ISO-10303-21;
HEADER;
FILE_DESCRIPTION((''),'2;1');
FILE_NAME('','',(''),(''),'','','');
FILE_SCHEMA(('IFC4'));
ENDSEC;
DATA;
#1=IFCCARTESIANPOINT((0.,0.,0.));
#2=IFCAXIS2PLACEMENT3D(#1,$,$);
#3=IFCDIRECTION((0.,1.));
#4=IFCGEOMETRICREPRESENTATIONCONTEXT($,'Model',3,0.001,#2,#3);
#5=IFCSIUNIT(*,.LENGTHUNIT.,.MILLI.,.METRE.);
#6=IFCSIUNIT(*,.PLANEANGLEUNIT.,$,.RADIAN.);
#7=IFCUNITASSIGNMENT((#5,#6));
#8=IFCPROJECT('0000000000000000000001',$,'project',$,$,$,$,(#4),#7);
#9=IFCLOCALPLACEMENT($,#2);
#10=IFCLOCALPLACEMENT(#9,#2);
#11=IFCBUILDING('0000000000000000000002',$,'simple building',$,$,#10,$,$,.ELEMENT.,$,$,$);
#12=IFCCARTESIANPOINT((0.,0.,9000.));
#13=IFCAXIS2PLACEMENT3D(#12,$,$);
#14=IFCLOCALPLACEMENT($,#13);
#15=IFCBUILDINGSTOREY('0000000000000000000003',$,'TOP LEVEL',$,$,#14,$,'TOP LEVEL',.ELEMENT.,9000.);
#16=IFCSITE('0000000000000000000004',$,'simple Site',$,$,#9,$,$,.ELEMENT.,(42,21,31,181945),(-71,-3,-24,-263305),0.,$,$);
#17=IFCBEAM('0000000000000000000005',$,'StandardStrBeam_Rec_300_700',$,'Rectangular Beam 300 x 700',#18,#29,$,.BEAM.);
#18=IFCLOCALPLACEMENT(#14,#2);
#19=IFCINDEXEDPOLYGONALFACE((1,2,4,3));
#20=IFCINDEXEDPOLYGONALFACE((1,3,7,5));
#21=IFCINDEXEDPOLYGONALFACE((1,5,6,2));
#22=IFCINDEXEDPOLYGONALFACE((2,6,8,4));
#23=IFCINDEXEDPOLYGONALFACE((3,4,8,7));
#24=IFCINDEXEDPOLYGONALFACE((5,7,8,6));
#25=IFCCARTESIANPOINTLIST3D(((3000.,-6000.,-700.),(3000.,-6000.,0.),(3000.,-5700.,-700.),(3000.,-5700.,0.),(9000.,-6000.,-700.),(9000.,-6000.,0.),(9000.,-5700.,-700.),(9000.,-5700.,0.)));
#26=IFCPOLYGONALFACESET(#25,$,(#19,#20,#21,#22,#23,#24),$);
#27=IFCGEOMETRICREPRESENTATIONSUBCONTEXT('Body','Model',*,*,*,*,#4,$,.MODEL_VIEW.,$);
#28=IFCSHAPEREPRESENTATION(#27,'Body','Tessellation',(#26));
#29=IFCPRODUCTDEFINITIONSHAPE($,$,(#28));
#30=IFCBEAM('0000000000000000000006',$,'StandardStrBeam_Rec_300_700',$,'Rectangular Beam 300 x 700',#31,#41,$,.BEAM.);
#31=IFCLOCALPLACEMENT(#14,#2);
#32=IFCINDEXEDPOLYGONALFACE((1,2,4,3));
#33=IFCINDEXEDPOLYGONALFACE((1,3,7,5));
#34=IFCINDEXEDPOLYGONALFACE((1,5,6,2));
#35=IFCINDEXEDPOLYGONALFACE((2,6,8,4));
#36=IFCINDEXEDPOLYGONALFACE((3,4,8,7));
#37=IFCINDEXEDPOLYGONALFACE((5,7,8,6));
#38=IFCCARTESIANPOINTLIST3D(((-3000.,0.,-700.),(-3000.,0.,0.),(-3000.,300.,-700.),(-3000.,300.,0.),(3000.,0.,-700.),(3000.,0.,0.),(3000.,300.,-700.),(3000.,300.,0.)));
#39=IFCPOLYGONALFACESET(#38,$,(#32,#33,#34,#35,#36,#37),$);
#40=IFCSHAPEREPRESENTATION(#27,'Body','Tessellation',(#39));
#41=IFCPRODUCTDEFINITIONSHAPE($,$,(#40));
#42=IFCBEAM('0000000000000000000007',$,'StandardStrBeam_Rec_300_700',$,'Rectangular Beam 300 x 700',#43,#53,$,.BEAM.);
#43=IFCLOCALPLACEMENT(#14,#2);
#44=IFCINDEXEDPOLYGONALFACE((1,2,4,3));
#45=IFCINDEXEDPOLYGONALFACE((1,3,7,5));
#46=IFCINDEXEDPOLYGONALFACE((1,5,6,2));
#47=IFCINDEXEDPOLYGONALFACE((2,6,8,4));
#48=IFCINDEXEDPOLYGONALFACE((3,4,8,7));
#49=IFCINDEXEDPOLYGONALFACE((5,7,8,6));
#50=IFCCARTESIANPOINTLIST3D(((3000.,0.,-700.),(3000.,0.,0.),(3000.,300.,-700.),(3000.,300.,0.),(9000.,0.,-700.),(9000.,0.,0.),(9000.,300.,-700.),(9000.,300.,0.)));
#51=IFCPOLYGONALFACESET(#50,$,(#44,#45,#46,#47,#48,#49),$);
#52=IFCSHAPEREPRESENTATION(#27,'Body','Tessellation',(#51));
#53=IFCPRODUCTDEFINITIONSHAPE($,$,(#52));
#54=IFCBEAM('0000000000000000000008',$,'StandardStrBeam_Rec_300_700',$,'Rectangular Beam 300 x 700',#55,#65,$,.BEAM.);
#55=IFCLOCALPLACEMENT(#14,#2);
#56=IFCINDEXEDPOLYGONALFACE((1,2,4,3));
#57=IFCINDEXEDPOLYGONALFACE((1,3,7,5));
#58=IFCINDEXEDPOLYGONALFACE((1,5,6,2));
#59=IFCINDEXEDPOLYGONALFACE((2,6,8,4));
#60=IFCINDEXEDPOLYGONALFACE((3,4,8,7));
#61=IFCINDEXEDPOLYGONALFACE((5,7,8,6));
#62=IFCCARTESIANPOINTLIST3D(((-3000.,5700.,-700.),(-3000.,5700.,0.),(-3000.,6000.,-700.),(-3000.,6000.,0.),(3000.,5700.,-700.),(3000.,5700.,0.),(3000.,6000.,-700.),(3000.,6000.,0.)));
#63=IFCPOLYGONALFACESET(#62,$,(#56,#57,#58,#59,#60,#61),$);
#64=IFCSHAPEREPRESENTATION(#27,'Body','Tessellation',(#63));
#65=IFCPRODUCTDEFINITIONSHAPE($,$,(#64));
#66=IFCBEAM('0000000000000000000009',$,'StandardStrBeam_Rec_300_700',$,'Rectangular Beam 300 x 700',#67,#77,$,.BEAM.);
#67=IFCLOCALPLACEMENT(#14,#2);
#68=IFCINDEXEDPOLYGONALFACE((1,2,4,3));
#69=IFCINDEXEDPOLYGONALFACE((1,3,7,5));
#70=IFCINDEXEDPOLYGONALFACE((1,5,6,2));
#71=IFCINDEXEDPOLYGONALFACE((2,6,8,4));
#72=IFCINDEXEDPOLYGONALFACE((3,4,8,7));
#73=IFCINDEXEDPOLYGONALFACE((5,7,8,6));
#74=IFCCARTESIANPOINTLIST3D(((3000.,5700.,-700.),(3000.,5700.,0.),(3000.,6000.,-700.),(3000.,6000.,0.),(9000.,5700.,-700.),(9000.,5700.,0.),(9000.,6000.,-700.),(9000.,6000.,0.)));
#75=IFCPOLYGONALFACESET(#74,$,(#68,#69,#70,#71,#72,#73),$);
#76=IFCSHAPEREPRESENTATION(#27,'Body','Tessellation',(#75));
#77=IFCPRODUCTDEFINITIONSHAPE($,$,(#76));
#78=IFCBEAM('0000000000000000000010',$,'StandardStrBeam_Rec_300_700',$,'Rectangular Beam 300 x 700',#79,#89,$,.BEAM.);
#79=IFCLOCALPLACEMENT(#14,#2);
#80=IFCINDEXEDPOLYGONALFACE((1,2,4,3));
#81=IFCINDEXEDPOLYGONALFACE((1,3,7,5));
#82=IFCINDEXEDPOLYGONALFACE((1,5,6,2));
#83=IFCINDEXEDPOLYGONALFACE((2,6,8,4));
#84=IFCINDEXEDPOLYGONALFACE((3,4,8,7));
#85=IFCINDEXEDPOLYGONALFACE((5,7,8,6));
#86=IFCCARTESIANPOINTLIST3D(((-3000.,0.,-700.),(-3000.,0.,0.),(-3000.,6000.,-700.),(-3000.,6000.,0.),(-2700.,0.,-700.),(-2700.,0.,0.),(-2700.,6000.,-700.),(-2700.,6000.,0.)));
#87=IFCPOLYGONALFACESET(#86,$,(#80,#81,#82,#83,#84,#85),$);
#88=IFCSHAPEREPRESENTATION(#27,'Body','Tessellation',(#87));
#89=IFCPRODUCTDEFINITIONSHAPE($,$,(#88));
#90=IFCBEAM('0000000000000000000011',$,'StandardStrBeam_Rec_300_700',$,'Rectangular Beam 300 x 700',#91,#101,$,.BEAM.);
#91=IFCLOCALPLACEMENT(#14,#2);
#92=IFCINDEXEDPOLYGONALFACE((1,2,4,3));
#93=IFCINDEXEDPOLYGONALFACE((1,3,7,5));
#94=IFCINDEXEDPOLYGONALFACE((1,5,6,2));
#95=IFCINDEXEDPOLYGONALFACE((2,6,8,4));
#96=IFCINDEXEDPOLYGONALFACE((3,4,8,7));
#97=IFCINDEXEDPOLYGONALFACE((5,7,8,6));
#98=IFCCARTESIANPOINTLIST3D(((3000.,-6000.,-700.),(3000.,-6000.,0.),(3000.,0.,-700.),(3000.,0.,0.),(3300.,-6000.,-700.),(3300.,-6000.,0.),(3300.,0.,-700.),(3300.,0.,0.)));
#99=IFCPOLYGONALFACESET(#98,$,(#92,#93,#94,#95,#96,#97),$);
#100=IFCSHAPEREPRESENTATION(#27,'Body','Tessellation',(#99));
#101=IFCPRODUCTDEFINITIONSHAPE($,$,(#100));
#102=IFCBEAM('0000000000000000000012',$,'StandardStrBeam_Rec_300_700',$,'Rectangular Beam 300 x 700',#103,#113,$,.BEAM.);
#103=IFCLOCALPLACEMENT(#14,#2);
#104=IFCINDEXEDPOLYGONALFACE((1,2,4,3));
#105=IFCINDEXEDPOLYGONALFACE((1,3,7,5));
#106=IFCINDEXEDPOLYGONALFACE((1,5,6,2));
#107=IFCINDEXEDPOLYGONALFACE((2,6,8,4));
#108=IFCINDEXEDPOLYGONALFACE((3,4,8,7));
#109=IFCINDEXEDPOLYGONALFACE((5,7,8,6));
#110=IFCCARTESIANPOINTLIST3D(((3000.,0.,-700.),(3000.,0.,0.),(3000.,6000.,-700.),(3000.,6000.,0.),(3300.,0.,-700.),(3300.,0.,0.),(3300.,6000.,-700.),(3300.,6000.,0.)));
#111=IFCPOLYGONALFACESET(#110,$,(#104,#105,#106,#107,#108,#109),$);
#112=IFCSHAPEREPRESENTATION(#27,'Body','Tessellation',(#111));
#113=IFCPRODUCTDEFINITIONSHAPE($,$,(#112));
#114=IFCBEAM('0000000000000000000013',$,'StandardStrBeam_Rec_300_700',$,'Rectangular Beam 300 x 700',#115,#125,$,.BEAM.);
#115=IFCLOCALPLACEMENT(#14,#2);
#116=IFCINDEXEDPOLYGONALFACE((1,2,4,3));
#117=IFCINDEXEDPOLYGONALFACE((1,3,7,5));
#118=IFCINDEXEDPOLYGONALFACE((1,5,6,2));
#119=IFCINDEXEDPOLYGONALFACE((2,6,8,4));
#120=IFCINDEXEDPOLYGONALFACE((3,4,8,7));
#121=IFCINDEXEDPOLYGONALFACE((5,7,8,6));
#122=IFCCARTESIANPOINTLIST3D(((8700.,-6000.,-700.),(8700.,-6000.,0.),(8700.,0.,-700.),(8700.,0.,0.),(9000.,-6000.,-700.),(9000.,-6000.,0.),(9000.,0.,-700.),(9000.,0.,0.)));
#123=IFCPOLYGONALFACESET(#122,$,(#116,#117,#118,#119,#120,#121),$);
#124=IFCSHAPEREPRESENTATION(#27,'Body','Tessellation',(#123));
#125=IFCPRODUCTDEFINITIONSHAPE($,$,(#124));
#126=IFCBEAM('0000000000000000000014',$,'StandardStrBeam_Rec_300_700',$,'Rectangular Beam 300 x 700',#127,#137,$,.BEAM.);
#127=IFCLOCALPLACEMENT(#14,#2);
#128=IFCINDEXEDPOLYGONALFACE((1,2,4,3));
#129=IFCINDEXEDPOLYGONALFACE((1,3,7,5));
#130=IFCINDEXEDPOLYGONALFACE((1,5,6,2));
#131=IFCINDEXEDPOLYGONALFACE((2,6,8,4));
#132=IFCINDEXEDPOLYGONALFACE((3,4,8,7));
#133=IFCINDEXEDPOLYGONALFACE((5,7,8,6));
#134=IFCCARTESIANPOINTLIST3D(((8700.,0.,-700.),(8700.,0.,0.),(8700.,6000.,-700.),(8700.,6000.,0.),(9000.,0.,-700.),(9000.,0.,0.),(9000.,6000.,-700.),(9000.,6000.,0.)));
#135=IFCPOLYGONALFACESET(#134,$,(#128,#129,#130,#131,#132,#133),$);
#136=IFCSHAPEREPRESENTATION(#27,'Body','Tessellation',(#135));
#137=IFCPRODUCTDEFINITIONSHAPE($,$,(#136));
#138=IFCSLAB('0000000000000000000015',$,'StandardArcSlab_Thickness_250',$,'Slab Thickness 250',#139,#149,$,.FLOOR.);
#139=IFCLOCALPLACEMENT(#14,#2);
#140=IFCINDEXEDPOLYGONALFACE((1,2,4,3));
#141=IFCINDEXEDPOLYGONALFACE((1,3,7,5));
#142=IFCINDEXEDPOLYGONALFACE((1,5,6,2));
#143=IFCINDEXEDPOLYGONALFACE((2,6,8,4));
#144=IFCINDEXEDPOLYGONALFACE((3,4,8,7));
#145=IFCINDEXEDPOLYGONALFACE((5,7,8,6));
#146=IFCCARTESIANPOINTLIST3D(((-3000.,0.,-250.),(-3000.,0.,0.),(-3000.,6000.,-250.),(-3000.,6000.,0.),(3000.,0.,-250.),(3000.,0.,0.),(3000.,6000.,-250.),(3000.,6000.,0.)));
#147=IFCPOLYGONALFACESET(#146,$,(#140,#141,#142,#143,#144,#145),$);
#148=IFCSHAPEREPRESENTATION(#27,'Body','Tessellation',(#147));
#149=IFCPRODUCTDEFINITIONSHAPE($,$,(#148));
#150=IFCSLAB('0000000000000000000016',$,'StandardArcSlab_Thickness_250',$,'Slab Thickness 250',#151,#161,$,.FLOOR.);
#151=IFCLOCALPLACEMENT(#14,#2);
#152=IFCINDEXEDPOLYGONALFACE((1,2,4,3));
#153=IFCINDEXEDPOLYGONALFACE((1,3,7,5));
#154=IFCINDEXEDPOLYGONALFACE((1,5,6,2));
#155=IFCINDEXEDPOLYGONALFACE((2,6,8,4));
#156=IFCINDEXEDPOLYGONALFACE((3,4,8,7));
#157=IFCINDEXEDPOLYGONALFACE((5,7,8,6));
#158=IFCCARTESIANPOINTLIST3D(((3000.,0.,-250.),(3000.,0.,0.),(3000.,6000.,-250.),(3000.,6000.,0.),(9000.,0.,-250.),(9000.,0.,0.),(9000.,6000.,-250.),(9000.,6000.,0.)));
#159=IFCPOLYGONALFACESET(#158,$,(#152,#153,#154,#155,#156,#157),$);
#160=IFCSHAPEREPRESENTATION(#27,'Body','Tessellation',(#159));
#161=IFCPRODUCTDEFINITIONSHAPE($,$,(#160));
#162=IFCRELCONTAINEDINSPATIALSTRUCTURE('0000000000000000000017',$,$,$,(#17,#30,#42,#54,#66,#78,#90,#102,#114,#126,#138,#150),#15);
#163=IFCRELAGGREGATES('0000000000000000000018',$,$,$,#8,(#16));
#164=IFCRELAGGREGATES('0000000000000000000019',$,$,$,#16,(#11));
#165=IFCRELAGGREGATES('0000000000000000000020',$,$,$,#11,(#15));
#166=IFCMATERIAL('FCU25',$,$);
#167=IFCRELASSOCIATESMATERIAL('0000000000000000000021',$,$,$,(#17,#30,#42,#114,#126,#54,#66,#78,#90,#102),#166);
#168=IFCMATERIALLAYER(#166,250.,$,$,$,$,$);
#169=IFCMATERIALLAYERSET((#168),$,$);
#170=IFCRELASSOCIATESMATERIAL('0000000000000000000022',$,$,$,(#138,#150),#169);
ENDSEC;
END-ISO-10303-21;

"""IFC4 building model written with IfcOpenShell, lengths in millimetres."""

from ifc_helpers import new_model, si_unit, direction, frame, origin, origin_with_axes, origin_2d_with_axis, place, context, subcontext, project, spatial, polyline, rectangle, outline, extrude, material, layer, layer_set, layer_usage, material_profile, profile_set, profile_usage, element, save


model = new_model("IFC4")

# Units and contexts
model_context = context("Model", 3, precision=0.001, world=origin(), true_north=direction((0.0, 1.0)))
body_context = subcontext(model_context, "Body", "Model", "MODEL_VIEW")
ifc_project = project(units=[si_unit("LENGTHUNIT", "METRE", prefix="MILLI"), si_unit("PLANEANGLEUNIT", "RADIAN")], contexts=[model_context])

# Site, building, storey
site_placement = place(None, origin())
site = spatial("IfcSite", under=ifc_project, at=site_placement, Name="simple Site", CompositionType="ELEMENT", RefLatitude=(42, 21, 31, 181945), RefLongitude=(-71, -3, -24, -263305), RefElevation=0.0)
building_placement = place(site_placement, origin())
building = spatial("IfcBuilding", under=site, at=building_placement, Name="simple building", CompositionType="ELEMENT")
storey_placement = place(None, frame((0.0, 0.0, 9000.0)))
storey = spatial("IfcBuildingStorey", under=building, at=storey_placement, Name="TOP LEVEL", LongName="TOP LEVEL", CompositionType="ELEMENT", Elevation=9000.0)

# Beams
ifc_material = material(Name="FCU25")
ifc_material_profile = material_profile(ifc_material, rectangle(XDim=300.0, YDim=700.0, at=origin_2d_with_axis()))
ifc_profile_set = profile_set([ifc_material_profile])
ifc_profile_usage_1 = profile_usage(ifc_profile_set, cardinal=9)
for number, where, z_axis, x_axis, name in (
    (1, (3000.0, -5850.0, 8650.0), (1.0, 0.0, 0.0), (0.0, -1.0, 0.0), "StandardStrBeam_Rec_300_700"),
    (2, (-3000.0, 150.0, 8650.0), (1.0, 0.0, 0.0), (0.0, -1.0, 0.0), "StandardStrBeam_Rec_300_700"),
    (3, (3000.0, 150.0, 8650.0), (1.0, 0.0, 0.0), (0.0, -1.0, 0.0), "StandardStrBeam_Rec_300_700"),
):
    element("IfcBeam", number, at=place(None, frame(where, z_axis=z_axis, x_axis=x_axis)), inside=storey, material=ifc_profile_usage_1, Name=name, ObjectType="Rectangular Beam 300 x 700", PredefinedType="BEAM", context=body_context, shape_type="SweptSolid", body=[
        extrude(rectangle(XDim=300.0, YDim=700.0, at=origin_2d_with_axis()), origin_with_axes(), (0.0, 0.0, 1.0), 6000.0),
    ])
ifc_profile_usage_2 = profile_usage(ifc_profile_set, cardinal=7)
for number, where, z_axis, x_axis, name in (
    (4, (-3000.0, 5850.0, 8650.0), (1.0, 0.0, 0.0), (0.0, -1.0, 0.0), "StandardStrBeam_Rec_300_700"),
    (5, (3000.0, 5850.0, 8650.0), (1.0, 0.0, 0.0), (0.0, -1.0, 0.0), "StandardStrBeam_Rec_300_700"),
    (6, (-2850.0, 0.0, 8650.0), (0.0, 1.0, 0.0), (1.0, 0.0, 0.0), "StandardStrBeam_Rec_300_700"),
    (7, (3150.0, -6000.0, 8650.0), (0.0, 1.0, 0.0), (1.0, 0.0, 0.0), "StandardStrBeam_Rec_300_700"),
    (8, (3150.0, 0.0, 8650.0), (0.0, 1.0, 0.0), (1.0, 0.0, 0.0), "StandardStrBeam_Rec_300_700"),
):
    element("IfcBeam", number, at=place(None, frame(where, z_axis=z_axis, x_axis=x_axis)), inside=storey, material=ifc_profile_usage_2, Name=name, ObjectType="Rectangular Beam 300 x 700", PredefinedType="BEAM", context=body_context, shape_type="SweptSolid", body=[
        extrude(rectangle(XDim=300.0, YDim=700.0, at=origin_2d_with_axis()), origin_with_axes(), (0.0, 0.0, 1.0), 6000.0),
    ])
for number, where, z_axis, x_axis, name in (
    (9, (8850.0, -6000.0, 8650.0), (0.0, 1.0, 0.0), (1.0, 0.0, 0.0), "StandardStrBeam_Rec_300_700"),
    (10, (8850.0, 0.0, 8650.0), (0.0, 1.0, 0.0), (1.0, 0.0, 0.0), "StandardStrBeam_Rec_300_700"),
):
    element("IfcBeam", number, at=place(None, frame(where, z_axis=z_axis, x_axis=x_axis)), inside=storey, material=ifc_profile_usage_1, Name=name, ObjectType="Rectangular Beam 300 x 700", PredefinedType="BEAM", context=body_context, shape_type="SweptSolid", body=[
        extrude(rectangle(XDim=300.0, YDim=700.0, at=origin_2d_with_axis()), origin_with_axes(), (0.0, 0.0, 1.0), 6000.0),
    ])

# Slabs
ifc_layer = layer(ifc_material, 250.0)
ifc_layer_set = layer_set([ifc_layer])
ifc_layer_usage = layer_usage(ifc_layer_set, "AXIS3", "POSITIVE", -250.0)
for number, where, z_axis, x_axis, name in (
    (11, (-3000.0, 0.0, 8750.0), (0.0, 0.0, 1.0), (1.0, 0.0, 0.0), "StandardArcSlab_Thickness_250"),
    (12, (3000.0, 0.0, 8750.0), (0.0, 0.0, 1.0), (1.0, 0.0, 0.0), "StandardArcSlab_Thickness_250"),
):
    element("IfcSlab", number, at=place(None, frame(where, z_axis=z_axis, x_axis=x_axis)), inside=storey, material=ifc_layer_usage, Name=name, ObjectType="Slab Thickness 250", PredefinedType="FLOOR", context=body_context, shape_type="SweptSolid", body=[
        extrude(outline(polyline([(0.0, 0.0), (6000.0, 0.0), (6000.0, 6000.0), (0.0, 6000.0), (0.0, 0.0)])), origin_with_axes(), (0.0, 0.0, 1.0), 250.0),
    ])

save(model, "model.ifc")
